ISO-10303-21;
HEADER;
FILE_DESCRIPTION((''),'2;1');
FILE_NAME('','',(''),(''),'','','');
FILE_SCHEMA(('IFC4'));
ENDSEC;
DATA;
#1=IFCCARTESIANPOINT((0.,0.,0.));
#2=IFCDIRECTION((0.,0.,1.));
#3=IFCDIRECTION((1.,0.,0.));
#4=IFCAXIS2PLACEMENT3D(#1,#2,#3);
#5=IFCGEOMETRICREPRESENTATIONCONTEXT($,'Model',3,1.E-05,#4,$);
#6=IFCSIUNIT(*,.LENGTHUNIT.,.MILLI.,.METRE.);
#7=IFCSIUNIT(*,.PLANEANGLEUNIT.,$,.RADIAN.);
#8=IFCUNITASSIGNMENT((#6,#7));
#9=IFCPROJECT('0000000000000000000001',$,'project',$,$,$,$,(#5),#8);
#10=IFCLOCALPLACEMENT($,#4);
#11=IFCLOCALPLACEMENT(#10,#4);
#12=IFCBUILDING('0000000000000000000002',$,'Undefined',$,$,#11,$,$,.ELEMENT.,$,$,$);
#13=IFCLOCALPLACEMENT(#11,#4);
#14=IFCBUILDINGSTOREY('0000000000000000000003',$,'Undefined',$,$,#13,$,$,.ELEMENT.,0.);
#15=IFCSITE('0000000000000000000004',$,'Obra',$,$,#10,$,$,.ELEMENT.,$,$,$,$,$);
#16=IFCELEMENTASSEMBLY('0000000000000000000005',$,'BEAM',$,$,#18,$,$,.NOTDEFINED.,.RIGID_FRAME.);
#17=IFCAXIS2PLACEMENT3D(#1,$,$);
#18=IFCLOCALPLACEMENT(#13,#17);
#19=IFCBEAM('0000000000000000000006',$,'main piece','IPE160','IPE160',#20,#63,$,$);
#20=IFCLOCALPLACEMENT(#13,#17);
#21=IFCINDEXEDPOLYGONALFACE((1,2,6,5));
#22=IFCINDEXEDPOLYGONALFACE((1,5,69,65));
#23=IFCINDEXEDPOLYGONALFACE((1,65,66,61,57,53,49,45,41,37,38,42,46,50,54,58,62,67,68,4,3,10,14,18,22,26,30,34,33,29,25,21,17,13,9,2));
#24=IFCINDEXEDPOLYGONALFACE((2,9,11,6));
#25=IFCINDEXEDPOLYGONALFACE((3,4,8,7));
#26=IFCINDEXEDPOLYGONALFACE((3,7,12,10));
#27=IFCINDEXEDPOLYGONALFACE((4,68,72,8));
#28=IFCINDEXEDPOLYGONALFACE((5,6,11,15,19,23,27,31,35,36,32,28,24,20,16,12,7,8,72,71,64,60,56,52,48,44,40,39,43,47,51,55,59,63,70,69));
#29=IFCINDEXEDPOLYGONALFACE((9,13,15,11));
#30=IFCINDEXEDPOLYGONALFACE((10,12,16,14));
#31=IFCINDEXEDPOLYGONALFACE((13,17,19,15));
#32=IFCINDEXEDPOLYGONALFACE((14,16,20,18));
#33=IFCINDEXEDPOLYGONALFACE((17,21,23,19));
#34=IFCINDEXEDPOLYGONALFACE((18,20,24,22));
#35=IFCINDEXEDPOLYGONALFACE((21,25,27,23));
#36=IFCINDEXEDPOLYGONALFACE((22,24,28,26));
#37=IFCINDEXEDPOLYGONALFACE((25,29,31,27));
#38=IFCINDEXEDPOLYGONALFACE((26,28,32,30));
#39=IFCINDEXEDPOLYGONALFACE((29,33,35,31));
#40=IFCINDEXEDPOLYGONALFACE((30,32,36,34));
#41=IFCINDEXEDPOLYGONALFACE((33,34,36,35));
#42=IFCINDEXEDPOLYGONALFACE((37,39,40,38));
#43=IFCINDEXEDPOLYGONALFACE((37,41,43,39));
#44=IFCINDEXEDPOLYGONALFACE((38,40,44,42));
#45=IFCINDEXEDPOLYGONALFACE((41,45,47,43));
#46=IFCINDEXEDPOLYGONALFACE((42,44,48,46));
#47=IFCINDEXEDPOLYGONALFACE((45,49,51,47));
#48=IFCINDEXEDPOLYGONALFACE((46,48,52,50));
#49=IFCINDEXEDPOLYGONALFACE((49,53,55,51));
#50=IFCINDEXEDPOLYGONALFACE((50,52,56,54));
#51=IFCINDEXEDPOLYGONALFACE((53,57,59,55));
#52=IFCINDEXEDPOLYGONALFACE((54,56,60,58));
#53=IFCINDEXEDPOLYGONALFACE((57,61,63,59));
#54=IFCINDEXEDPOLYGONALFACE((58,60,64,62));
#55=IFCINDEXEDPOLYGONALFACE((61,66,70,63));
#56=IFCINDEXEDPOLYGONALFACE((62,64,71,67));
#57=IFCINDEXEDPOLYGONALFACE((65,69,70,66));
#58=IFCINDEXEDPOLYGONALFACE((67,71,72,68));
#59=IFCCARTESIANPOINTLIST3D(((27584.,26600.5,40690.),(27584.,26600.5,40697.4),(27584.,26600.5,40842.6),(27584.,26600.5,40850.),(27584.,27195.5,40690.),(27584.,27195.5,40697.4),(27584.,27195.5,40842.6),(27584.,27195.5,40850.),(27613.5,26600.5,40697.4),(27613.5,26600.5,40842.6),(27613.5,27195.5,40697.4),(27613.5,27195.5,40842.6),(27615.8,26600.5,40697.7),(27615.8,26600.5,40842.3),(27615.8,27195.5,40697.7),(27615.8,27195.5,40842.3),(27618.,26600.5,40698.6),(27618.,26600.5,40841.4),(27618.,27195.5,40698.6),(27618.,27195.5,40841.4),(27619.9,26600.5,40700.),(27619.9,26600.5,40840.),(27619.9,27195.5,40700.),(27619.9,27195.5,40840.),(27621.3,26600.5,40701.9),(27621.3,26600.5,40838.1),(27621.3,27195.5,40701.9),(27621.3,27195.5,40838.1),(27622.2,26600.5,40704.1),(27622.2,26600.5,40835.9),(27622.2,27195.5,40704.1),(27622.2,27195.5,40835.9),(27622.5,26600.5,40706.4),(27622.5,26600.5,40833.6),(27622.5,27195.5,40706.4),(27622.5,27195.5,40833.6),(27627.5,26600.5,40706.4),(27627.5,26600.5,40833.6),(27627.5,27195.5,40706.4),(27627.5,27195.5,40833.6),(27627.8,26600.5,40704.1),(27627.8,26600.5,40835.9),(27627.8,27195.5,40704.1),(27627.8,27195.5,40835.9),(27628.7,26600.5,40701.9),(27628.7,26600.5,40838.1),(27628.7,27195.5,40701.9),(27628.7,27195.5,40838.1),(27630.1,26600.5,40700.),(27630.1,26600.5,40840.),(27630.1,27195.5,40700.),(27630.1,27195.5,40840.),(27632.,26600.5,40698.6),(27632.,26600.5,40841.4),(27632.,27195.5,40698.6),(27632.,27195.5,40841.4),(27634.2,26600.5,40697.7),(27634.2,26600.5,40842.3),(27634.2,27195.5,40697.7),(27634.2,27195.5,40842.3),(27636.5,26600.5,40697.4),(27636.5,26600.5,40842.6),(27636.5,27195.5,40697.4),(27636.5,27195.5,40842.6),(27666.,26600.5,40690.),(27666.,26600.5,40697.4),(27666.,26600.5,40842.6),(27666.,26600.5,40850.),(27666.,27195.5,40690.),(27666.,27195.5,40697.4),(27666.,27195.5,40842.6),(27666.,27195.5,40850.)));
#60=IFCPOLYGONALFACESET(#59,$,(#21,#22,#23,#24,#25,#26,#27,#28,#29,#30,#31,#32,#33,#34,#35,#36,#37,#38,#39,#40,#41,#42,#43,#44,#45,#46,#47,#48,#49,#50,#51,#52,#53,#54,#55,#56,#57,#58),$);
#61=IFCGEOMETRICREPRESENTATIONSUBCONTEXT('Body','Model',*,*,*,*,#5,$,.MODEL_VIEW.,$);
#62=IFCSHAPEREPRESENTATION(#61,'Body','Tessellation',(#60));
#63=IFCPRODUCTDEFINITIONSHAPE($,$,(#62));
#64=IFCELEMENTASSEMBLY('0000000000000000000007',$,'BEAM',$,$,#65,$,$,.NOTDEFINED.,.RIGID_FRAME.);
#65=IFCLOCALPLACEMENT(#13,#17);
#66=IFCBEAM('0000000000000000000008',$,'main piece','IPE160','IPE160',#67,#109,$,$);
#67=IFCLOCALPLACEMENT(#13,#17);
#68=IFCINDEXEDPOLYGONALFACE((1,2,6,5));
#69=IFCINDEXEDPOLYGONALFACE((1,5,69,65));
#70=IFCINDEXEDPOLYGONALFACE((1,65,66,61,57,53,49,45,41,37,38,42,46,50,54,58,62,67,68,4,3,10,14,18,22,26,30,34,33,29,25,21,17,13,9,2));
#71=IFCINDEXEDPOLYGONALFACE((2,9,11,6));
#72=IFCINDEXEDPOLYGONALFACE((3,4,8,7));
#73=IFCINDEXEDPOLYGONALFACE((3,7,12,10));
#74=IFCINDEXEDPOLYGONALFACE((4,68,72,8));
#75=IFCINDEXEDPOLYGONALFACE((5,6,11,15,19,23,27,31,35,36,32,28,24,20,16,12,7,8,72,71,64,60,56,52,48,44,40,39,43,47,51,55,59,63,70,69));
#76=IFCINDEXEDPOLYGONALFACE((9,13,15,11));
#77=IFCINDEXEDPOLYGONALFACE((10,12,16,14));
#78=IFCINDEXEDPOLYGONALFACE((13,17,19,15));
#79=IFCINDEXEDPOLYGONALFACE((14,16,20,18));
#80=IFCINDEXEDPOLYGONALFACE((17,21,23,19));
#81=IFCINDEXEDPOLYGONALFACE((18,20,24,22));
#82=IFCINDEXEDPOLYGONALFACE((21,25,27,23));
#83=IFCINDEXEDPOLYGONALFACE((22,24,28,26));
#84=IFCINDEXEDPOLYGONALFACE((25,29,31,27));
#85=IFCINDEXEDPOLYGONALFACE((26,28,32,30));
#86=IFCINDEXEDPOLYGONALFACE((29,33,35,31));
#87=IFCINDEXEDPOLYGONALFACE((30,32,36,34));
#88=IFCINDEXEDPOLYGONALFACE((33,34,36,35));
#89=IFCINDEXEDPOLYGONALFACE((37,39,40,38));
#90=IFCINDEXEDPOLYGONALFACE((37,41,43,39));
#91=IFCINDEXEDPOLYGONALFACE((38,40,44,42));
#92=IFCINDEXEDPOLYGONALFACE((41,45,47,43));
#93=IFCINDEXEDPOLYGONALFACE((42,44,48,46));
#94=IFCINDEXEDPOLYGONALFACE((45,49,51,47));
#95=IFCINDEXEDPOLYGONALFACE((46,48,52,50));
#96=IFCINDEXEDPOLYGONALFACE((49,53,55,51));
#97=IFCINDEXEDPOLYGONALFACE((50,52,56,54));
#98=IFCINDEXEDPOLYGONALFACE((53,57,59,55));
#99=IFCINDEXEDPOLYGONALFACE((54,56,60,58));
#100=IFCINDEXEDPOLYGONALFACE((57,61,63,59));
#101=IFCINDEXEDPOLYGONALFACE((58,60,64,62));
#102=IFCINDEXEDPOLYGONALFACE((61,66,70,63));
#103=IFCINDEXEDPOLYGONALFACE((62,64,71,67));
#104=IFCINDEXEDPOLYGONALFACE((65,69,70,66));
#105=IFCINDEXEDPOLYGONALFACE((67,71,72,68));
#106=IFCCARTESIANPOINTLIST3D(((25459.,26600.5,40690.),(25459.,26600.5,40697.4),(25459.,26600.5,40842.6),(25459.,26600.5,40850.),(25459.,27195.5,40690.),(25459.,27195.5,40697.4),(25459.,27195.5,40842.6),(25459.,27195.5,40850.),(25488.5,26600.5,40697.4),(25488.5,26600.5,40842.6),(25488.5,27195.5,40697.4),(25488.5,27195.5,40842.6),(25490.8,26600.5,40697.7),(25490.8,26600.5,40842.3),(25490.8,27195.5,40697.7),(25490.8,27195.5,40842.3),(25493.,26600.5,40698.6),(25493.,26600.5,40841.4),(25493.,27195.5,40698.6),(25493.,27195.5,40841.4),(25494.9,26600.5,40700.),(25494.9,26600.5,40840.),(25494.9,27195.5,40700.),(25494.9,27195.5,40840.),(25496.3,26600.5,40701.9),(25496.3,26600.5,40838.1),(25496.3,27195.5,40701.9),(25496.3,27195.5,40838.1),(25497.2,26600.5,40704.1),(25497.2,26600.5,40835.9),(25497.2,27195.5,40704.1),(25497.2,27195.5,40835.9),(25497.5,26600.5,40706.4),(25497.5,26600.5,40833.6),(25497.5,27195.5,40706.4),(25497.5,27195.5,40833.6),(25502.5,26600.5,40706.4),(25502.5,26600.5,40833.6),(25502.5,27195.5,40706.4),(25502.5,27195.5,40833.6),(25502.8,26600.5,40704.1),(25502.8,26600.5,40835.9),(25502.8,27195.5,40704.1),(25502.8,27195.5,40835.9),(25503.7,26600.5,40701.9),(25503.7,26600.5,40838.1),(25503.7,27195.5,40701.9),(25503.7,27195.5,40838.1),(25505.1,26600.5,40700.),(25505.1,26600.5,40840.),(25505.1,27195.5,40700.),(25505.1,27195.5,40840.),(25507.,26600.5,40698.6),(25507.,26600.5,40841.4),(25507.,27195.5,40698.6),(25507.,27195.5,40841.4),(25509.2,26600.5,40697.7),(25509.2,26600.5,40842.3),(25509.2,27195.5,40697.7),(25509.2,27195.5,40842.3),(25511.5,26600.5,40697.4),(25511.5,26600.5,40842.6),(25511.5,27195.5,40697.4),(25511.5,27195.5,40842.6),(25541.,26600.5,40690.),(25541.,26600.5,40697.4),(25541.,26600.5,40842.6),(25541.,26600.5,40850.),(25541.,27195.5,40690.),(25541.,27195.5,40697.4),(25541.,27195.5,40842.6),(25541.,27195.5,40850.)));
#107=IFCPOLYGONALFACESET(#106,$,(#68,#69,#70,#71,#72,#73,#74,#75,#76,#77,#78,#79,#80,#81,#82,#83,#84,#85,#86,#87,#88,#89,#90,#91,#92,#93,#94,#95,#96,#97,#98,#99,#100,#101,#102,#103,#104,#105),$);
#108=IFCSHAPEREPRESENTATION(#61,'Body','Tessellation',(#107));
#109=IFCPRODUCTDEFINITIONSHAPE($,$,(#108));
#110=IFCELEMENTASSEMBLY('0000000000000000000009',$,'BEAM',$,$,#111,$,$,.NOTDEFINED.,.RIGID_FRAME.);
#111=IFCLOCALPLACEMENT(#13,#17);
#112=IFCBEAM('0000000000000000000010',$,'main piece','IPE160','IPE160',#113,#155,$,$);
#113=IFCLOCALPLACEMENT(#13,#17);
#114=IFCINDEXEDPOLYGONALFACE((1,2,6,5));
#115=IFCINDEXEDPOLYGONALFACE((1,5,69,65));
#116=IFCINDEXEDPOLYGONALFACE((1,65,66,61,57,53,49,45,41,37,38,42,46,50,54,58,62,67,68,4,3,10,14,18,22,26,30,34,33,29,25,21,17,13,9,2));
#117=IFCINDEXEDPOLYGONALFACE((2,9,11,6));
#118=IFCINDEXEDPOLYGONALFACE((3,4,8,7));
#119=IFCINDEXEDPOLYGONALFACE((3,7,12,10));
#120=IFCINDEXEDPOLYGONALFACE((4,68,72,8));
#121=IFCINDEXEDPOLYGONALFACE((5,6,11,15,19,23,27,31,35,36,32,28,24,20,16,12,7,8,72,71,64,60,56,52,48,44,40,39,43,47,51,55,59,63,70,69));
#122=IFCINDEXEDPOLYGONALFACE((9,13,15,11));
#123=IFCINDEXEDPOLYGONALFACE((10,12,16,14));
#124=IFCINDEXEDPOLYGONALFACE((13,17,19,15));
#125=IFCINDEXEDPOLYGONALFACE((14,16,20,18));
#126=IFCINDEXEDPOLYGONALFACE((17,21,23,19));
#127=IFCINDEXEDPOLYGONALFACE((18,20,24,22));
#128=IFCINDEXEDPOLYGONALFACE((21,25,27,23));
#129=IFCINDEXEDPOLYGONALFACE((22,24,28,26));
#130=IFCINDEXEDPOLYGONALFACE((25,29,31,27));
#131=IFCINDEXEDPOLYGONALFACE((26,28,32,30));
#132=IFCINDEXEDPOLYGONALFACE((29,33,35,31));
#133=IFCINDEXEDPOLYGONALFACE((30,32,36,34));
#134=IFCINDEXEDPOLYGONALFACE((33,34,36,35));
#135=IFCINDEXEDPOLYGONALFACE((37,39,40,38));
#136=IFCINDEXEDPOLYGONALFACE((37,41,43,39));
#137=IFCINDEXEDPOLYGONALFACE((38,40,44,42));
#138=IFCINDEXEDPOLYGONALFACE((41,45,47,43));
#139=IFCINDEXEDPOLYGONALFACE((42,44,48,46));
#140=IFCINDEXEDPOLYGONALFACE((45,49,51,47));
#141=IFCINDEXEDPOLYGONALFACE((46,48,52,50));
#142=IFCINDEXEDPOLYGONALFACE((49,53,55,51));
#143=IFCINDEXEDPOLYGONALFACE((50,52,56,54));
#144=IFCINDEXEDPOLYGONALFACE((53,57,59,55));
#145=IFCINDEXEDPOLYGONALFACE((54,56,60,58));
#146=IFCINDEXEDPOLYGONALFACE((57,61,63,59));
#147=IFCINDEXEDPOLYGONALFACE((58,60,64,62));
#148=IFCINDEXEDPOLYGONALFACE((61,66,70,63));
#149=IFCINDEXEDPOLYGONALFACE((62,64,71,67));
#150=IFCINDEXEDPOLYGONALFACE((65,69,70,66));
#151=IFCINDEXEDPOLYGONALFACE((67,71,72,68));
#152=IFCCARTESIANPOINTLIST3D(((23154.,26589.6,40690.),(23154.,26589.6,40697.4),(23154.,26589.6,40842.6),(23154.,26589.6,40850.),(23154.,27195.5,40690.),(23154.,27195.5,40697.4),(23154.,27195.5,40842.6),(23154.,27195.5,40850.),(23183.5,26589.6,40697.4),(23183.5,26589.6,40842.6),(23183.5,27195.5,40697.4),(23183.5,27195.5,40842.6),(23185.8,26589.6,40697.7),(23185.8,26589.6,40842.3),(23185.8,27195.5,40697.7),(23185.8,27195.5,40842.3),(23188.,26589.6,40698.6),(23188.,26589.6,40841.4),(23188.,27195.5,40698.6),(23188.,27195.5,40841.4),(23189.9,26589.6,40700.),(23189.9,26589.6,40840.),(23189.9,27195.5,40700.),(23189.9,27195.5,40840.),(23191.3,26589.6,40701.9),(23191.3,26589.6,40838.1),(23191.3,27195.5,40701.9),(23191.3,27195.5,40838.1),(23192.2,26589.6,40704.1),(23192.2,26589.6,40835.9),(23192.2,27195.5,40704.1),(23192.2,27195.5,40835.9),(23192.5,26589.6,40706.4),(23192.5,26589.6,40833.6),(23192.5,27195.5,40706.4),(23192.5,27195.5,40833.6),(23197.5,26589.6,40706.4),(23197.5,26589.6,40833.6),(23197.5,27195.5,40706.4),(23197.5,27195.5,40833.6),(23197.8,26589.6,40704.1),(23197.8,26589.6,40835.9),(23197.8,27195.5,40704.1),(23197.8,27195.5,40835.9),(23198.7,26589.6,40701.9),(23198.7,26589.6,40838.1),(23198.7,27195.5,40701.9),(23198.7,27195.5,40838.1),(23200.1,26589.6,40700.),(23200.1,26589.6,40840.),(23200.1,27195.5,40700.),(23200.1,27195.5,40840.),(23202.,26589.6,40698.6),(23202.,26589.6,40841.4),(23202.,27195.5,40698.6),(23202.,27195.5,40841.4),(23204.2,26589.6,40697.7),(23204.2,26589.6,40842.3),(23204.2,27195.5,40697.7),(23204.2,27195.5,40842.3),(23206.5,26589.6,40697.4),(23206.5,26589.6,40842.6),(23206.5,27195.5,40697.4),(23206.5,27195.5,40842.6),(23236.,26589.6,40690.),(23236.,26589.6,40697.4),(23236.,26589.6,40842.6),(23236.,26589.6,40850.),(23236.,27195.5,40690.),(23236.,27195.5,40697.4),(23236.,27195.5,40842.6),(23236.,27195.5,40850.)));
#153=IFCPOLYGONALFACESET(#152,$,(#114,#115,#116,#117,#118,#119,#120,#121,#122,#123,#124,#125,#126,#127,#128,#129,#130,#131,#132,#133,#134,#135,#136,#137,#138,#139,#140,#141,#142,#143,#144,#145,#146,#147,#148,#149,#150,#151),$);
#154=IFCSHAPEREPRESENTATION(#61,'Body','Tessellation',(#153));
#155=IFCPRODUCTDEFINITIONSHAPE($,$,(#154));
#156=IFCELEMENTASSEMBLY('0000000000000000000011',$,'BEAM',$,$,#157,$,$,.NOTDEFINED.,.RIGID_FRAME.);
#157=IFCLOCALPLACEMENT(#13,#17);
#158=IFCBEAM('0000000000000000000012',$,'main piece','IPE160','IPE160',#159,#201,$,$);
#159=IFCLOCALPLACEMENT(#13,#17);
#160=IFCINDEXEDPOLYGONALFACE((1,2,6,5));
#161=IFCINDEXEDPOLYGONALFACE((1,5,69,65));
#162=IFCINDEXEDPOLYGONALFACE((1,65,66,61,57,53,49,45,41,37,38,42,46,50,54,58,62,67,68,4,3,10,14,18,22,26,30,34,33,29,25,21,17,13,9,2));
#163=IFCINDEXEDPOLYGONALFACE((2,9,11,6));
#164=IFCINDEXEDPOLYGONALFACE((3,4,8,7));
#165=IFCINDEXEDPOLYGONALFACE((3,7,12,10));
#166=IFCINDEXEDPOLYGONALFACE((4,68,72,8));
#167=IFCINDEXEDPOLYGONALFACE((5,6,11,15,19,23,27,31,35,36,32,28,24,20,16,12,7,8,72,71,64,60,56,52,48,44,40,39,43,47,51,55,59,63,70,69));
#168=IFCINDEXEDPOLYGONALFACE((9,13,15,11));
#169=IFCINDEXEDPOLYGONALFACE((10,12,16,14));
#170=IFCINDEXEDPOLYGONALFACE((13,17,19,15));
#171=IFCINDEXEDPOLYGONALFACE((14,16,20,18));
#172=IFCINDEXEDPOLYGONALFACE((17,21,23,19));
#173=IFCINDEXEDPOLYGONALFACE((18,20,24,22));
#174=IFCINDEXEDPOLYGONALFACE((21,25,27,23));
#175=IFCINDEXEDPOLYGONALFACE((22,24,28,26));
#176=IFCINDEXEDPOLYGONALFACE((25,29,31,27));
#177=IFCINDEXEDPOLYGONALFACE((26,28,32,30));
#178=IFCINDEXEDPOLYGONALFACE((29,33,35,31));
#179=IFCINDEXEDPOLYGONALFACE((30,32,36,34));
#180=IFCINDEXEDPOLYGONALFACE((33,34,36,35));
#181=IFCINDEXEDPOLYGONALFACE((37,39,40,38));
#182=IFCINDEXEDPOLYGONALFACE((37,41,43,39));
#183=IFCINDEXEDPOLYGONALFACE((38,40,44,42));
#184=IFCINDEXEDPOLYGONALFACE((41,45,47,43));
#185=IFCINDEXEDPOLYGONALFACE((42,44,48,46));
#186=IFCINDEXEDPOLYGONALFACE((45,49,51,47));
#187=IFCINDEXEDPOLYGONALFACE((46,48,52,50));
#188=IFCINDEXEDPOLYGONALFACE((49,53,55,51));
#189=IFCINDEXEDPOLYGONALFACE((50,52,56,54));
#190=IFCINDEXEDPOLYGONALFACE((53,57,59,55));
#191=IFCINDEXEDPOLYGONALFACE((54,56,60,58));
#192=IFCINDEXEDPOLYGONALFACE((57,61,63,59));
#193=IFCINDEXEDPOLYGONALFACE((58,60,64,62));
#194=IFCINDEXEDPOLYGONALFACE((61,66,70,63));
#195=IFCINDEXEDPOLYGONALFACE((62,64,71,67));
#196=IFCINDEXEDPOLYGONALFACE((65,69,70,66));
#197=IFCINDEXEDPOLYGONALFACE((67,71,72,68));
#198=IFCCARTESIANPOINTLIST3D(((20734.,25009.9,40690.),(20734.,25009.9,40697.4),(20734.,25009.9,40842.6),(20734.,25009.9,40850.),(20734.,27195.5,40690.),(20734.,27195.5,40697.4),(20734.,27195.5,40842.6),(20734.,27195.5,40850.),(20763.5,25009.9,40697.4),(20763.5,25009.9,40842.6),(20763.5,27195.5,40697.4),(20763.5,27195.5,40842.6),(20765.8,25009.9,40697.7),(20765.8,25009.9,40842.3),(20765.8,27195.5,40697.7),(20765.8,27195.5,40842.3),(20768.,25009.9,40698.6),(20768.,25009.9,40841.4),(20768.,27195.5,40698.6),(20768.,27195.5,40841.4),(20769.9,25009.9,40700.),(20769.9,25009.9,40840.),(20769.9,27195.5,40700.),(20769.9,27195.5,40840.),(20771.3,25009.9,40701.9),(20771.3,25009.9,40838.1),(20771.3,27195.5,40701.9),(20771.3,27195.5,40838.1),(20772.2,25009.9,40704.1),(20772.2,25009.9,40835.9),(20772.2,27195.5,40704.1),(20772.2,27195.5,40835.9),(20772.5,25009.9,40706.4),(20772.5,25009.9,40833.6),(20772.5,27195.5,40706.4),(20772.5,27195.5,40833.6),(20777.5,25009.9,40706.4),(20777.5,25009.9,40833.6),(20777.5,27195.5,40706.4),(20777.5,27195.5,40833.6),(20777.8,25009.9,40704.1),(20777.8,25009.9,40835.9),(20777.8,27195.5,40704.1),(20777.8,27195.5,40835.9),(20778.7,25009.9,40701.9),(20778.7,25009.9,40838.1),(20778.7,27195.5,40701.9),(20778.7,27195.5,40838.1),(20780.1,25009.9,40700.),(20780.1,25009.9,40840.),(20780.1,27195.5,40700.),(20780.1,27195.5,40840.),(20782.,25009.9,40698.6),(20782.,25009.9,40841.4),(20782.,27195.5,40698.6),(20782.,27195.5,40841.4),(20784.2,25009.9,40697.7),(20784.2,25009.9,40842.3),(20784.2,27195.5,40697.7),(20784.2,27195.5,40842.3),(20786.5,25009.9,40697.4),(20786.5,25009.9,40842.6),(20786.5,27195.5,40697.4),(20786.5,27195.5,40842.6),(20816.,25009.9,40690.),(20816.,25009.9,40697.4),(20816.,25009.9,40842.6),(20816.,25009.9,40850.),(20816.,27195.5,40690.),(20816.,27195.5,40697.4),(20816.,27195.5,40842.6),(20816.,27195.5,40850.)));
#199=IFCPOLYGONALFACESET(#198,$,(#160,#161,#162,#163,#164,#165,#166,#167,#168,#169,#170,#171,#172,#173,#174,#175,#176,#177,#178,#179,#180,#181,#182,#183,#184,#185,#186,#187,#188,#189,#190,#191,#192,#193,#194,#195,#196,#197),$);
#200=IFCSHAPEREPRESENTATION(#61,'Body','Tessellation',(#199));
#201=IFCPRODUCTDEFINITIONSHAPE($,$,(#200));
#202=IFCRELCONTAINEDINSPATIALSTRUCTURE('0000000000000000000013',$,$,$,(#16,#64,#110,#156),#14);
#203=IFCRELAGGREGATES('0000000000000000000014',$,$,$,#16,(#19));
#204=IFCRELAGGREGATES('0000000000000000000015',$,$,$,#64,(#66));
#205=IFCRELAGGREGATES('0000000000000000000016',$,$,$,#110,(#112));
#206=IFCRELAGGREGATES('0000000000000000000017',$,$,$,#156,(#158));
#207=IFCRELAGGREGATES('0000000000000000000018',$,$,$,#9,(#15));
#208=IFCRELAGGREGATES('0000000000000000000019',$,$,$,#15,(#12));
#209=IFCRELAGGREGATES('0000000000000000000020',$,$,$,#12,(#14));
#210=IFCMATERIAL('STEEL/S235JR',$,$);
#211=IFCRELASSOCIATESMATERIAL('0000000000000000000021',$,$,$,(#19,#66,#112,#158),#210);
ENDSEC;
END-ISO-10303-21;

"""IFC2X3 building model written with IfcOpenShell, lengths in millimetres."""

from ifc_helpers import new_model, si_unit, frame, origin_with_axes, origin_2d_with_axis, place, context, subcontext, project, spatial, i_section, extrude, material, element, aggregate, save


model = new_model("IFC2X3")

# Units and contexts
model_context = context("Model", 3, precision=1e-05, world=origin_with_axes())
body_context = subcontext(model_context, "Body", "Model", "MODEL_VIEW")
ifc_project = project(units=[si_unit("LENGTHUNIT", "METRE", prefix="MILLI"), si_unit("PLANEANGLEUNIT", "RADIAN")], contexts=[model_context])

# Site, building, storey
site_placement = place(None, origin_with_axes())
site = spatial("IfcSite", under=ifc_project, at=site_placement, Name="Obra", CompositionType="ELEMENT")
building_placement = place(site_placement, origin_with_axes())
building = spatial("IfcBuilding", under=site, at=building_placement, Name="Undefined", CompositionType="ELEMENT")
storey_placement = place(building_placement, origin_with_axes())
storey = spatial("IfcBuildingStorey", under=building, at=storey_placement, Name="Undefined", CompositionType="ELEMENT", Elevation=0.0)

# Shared definitions
ifc_material_1 = material(Name="STEEL/S235JR")

# Element assemblies, beams
assembly_1_placement = place(storey_placement, origin_with_axes())
assembly_1 = element("IfcElementAssembly", 1, at=assembly_1_placement, inside=storey, Name="BEAM", AssemblyPlace="NOTDEFINED", PredefinedType="RIGID_FRAME")
beam_1_placement = place(assembly_1_placement, frame((27625.0, 26600.5, 40770.0), z_axis=(0.0, 0.0, 1.0), x_axis=(0.0, 1.0, 0.0)))
beam_1 = element("IfcBeam", 2, at=beam_1_placement, material=ifc_material_1, Name="main piece", Description="IPE160", ObjectType="IPE160", context=body_context, shape_type="SweptSolid", body=[
    extrude(i_section(OverallWidth=82.0, OverallDepth=160.0, WebThickness=5.0, FlangeThickness=7.4, FilletRadius=9.0, at=origin_2d_with_axis()), frame((595.0, 0.0, 0.0), z_axis=(-1.0, 0.0, 0.0), x_axis=(0.0, -1.0, 0.0)), (0.0, 0.0, 1.0), 595.0),
])
aggregate(assembly_1, [beam_1])
assembly_2_placement = place(storey_placement, origin_with_axes())
assembly_2 = element("IfcElementAssembly", 3, at=assembly_2_placement, inside=storey, Name="BEAM", AssemblyPlace="NOTDEFINED", PredefinedType="RIGID_FRAME")
beam_2_placement = place(assembly_2_placement, frame((25500.0, 26600.5, 40770.0), z_axis=(0.0, 0.0, 1.0), x_axis=(0.0, 1.0, 0.0)))
beam_2 = element("IfcBeam", 4, at=beam_2_placement, material=ifc_material_1, Name="main piece", Description="IPE160", ObjectType="IPE160", context=body_context, shape_type="SweptSolid", body=[
    extrude(i_section(OverallWidth=82.0, OverallDepth=160.0, WebThickness=5.0, FlangeThickness=7.4, FilletRadius=9.0, at=origin_2d_with_axis()), frame((595.0, 0.0, 0.0), z_axis=(-1.0, 0.0, 0.0), x_axis=(0.0, -1.0, 0.0)), (0.0, 0.0, 1.0), 595.0),
])
aggregate(assembly_2, [beam_2])
assembly_3_placement = place(storey_placement, origin_with_axes())
assembly_3 = element("IfcElementAssembly", 5, at=assembly_3_placement, inside=storey, Name="BEAM", AssemblyPlace="NOTDEFINED", PredefinedType="RIGID_FRAME")
beam_3_placement = place(assembly_3_placement, frame((23195.0, 26589.6, 40770.0), z_axis=(0.0, 0.0, 1.0), x_axis=(0.0, 1.0, 0.0)))
beam_3 = element("IfcBeam", 6, at=beam_3_placement, material=ifc_material_1, Name="main piece", Description="IPE160", ObjectType="IPE160", context=body_context, shape_type="SweptSolid", body=[
    extrude(i_section(OverallWidth=82.0, OverallDepth=160.0, WebThickness=5.0, FlangeThickness=7.4, FilletRadius=9.0, at=origin_2d_with_axis()), frame((605.9, 0.0, 0.0), z_axis=(-1.0, 0.0, 0.0), x_axis=(0.0, -1.0, 0.0)), (0.0, 0.0, 1.0), 605.9),
])
aggregate(assembly_3, [beam_3])
assembly_4_placement = place(storey_placement, origin_with_axes())
assembly_4 = element("IfcElementAssembly", 7, at=assembly_4_placement, inside=storey, Name="BEAM", AssemblyPlace="NOTDEFINED", PredefinedType="RIGID_FRAME")
beam_4_placement = place(assembly_4_placement, frame((20775.0, 25009.9, 40770.0), z_axis=(0.0, 0.0, 1.0), x_axis=(0.0, 1.0, 0.0)))
beam_4 = element("IfcBeam", 8, at=beam_4_placement, material=ifc_material_1, Name="main piece", Description="IPE160", ObjectType="IPE160", context=body_context, shape_type="SweptSolid", body=[
    extrude(i_section(OverallWidth=82.0, OverallDepth=160.0, WebThickness=5.0, FlangeThickness=7.4, FilletRadius=9.0, at=origin_2d_with_axis()), frame((2185.6, 0.0, 0.0), z_axis=(-1.0, 0.0, 0.0), x_axis=(0.0, -1.0, 0.0)), (0.0, 0.0, 1.0), 2185.6),
])
aggregate(assembly_4, [beam_4])

save(model, "model.ifc")
